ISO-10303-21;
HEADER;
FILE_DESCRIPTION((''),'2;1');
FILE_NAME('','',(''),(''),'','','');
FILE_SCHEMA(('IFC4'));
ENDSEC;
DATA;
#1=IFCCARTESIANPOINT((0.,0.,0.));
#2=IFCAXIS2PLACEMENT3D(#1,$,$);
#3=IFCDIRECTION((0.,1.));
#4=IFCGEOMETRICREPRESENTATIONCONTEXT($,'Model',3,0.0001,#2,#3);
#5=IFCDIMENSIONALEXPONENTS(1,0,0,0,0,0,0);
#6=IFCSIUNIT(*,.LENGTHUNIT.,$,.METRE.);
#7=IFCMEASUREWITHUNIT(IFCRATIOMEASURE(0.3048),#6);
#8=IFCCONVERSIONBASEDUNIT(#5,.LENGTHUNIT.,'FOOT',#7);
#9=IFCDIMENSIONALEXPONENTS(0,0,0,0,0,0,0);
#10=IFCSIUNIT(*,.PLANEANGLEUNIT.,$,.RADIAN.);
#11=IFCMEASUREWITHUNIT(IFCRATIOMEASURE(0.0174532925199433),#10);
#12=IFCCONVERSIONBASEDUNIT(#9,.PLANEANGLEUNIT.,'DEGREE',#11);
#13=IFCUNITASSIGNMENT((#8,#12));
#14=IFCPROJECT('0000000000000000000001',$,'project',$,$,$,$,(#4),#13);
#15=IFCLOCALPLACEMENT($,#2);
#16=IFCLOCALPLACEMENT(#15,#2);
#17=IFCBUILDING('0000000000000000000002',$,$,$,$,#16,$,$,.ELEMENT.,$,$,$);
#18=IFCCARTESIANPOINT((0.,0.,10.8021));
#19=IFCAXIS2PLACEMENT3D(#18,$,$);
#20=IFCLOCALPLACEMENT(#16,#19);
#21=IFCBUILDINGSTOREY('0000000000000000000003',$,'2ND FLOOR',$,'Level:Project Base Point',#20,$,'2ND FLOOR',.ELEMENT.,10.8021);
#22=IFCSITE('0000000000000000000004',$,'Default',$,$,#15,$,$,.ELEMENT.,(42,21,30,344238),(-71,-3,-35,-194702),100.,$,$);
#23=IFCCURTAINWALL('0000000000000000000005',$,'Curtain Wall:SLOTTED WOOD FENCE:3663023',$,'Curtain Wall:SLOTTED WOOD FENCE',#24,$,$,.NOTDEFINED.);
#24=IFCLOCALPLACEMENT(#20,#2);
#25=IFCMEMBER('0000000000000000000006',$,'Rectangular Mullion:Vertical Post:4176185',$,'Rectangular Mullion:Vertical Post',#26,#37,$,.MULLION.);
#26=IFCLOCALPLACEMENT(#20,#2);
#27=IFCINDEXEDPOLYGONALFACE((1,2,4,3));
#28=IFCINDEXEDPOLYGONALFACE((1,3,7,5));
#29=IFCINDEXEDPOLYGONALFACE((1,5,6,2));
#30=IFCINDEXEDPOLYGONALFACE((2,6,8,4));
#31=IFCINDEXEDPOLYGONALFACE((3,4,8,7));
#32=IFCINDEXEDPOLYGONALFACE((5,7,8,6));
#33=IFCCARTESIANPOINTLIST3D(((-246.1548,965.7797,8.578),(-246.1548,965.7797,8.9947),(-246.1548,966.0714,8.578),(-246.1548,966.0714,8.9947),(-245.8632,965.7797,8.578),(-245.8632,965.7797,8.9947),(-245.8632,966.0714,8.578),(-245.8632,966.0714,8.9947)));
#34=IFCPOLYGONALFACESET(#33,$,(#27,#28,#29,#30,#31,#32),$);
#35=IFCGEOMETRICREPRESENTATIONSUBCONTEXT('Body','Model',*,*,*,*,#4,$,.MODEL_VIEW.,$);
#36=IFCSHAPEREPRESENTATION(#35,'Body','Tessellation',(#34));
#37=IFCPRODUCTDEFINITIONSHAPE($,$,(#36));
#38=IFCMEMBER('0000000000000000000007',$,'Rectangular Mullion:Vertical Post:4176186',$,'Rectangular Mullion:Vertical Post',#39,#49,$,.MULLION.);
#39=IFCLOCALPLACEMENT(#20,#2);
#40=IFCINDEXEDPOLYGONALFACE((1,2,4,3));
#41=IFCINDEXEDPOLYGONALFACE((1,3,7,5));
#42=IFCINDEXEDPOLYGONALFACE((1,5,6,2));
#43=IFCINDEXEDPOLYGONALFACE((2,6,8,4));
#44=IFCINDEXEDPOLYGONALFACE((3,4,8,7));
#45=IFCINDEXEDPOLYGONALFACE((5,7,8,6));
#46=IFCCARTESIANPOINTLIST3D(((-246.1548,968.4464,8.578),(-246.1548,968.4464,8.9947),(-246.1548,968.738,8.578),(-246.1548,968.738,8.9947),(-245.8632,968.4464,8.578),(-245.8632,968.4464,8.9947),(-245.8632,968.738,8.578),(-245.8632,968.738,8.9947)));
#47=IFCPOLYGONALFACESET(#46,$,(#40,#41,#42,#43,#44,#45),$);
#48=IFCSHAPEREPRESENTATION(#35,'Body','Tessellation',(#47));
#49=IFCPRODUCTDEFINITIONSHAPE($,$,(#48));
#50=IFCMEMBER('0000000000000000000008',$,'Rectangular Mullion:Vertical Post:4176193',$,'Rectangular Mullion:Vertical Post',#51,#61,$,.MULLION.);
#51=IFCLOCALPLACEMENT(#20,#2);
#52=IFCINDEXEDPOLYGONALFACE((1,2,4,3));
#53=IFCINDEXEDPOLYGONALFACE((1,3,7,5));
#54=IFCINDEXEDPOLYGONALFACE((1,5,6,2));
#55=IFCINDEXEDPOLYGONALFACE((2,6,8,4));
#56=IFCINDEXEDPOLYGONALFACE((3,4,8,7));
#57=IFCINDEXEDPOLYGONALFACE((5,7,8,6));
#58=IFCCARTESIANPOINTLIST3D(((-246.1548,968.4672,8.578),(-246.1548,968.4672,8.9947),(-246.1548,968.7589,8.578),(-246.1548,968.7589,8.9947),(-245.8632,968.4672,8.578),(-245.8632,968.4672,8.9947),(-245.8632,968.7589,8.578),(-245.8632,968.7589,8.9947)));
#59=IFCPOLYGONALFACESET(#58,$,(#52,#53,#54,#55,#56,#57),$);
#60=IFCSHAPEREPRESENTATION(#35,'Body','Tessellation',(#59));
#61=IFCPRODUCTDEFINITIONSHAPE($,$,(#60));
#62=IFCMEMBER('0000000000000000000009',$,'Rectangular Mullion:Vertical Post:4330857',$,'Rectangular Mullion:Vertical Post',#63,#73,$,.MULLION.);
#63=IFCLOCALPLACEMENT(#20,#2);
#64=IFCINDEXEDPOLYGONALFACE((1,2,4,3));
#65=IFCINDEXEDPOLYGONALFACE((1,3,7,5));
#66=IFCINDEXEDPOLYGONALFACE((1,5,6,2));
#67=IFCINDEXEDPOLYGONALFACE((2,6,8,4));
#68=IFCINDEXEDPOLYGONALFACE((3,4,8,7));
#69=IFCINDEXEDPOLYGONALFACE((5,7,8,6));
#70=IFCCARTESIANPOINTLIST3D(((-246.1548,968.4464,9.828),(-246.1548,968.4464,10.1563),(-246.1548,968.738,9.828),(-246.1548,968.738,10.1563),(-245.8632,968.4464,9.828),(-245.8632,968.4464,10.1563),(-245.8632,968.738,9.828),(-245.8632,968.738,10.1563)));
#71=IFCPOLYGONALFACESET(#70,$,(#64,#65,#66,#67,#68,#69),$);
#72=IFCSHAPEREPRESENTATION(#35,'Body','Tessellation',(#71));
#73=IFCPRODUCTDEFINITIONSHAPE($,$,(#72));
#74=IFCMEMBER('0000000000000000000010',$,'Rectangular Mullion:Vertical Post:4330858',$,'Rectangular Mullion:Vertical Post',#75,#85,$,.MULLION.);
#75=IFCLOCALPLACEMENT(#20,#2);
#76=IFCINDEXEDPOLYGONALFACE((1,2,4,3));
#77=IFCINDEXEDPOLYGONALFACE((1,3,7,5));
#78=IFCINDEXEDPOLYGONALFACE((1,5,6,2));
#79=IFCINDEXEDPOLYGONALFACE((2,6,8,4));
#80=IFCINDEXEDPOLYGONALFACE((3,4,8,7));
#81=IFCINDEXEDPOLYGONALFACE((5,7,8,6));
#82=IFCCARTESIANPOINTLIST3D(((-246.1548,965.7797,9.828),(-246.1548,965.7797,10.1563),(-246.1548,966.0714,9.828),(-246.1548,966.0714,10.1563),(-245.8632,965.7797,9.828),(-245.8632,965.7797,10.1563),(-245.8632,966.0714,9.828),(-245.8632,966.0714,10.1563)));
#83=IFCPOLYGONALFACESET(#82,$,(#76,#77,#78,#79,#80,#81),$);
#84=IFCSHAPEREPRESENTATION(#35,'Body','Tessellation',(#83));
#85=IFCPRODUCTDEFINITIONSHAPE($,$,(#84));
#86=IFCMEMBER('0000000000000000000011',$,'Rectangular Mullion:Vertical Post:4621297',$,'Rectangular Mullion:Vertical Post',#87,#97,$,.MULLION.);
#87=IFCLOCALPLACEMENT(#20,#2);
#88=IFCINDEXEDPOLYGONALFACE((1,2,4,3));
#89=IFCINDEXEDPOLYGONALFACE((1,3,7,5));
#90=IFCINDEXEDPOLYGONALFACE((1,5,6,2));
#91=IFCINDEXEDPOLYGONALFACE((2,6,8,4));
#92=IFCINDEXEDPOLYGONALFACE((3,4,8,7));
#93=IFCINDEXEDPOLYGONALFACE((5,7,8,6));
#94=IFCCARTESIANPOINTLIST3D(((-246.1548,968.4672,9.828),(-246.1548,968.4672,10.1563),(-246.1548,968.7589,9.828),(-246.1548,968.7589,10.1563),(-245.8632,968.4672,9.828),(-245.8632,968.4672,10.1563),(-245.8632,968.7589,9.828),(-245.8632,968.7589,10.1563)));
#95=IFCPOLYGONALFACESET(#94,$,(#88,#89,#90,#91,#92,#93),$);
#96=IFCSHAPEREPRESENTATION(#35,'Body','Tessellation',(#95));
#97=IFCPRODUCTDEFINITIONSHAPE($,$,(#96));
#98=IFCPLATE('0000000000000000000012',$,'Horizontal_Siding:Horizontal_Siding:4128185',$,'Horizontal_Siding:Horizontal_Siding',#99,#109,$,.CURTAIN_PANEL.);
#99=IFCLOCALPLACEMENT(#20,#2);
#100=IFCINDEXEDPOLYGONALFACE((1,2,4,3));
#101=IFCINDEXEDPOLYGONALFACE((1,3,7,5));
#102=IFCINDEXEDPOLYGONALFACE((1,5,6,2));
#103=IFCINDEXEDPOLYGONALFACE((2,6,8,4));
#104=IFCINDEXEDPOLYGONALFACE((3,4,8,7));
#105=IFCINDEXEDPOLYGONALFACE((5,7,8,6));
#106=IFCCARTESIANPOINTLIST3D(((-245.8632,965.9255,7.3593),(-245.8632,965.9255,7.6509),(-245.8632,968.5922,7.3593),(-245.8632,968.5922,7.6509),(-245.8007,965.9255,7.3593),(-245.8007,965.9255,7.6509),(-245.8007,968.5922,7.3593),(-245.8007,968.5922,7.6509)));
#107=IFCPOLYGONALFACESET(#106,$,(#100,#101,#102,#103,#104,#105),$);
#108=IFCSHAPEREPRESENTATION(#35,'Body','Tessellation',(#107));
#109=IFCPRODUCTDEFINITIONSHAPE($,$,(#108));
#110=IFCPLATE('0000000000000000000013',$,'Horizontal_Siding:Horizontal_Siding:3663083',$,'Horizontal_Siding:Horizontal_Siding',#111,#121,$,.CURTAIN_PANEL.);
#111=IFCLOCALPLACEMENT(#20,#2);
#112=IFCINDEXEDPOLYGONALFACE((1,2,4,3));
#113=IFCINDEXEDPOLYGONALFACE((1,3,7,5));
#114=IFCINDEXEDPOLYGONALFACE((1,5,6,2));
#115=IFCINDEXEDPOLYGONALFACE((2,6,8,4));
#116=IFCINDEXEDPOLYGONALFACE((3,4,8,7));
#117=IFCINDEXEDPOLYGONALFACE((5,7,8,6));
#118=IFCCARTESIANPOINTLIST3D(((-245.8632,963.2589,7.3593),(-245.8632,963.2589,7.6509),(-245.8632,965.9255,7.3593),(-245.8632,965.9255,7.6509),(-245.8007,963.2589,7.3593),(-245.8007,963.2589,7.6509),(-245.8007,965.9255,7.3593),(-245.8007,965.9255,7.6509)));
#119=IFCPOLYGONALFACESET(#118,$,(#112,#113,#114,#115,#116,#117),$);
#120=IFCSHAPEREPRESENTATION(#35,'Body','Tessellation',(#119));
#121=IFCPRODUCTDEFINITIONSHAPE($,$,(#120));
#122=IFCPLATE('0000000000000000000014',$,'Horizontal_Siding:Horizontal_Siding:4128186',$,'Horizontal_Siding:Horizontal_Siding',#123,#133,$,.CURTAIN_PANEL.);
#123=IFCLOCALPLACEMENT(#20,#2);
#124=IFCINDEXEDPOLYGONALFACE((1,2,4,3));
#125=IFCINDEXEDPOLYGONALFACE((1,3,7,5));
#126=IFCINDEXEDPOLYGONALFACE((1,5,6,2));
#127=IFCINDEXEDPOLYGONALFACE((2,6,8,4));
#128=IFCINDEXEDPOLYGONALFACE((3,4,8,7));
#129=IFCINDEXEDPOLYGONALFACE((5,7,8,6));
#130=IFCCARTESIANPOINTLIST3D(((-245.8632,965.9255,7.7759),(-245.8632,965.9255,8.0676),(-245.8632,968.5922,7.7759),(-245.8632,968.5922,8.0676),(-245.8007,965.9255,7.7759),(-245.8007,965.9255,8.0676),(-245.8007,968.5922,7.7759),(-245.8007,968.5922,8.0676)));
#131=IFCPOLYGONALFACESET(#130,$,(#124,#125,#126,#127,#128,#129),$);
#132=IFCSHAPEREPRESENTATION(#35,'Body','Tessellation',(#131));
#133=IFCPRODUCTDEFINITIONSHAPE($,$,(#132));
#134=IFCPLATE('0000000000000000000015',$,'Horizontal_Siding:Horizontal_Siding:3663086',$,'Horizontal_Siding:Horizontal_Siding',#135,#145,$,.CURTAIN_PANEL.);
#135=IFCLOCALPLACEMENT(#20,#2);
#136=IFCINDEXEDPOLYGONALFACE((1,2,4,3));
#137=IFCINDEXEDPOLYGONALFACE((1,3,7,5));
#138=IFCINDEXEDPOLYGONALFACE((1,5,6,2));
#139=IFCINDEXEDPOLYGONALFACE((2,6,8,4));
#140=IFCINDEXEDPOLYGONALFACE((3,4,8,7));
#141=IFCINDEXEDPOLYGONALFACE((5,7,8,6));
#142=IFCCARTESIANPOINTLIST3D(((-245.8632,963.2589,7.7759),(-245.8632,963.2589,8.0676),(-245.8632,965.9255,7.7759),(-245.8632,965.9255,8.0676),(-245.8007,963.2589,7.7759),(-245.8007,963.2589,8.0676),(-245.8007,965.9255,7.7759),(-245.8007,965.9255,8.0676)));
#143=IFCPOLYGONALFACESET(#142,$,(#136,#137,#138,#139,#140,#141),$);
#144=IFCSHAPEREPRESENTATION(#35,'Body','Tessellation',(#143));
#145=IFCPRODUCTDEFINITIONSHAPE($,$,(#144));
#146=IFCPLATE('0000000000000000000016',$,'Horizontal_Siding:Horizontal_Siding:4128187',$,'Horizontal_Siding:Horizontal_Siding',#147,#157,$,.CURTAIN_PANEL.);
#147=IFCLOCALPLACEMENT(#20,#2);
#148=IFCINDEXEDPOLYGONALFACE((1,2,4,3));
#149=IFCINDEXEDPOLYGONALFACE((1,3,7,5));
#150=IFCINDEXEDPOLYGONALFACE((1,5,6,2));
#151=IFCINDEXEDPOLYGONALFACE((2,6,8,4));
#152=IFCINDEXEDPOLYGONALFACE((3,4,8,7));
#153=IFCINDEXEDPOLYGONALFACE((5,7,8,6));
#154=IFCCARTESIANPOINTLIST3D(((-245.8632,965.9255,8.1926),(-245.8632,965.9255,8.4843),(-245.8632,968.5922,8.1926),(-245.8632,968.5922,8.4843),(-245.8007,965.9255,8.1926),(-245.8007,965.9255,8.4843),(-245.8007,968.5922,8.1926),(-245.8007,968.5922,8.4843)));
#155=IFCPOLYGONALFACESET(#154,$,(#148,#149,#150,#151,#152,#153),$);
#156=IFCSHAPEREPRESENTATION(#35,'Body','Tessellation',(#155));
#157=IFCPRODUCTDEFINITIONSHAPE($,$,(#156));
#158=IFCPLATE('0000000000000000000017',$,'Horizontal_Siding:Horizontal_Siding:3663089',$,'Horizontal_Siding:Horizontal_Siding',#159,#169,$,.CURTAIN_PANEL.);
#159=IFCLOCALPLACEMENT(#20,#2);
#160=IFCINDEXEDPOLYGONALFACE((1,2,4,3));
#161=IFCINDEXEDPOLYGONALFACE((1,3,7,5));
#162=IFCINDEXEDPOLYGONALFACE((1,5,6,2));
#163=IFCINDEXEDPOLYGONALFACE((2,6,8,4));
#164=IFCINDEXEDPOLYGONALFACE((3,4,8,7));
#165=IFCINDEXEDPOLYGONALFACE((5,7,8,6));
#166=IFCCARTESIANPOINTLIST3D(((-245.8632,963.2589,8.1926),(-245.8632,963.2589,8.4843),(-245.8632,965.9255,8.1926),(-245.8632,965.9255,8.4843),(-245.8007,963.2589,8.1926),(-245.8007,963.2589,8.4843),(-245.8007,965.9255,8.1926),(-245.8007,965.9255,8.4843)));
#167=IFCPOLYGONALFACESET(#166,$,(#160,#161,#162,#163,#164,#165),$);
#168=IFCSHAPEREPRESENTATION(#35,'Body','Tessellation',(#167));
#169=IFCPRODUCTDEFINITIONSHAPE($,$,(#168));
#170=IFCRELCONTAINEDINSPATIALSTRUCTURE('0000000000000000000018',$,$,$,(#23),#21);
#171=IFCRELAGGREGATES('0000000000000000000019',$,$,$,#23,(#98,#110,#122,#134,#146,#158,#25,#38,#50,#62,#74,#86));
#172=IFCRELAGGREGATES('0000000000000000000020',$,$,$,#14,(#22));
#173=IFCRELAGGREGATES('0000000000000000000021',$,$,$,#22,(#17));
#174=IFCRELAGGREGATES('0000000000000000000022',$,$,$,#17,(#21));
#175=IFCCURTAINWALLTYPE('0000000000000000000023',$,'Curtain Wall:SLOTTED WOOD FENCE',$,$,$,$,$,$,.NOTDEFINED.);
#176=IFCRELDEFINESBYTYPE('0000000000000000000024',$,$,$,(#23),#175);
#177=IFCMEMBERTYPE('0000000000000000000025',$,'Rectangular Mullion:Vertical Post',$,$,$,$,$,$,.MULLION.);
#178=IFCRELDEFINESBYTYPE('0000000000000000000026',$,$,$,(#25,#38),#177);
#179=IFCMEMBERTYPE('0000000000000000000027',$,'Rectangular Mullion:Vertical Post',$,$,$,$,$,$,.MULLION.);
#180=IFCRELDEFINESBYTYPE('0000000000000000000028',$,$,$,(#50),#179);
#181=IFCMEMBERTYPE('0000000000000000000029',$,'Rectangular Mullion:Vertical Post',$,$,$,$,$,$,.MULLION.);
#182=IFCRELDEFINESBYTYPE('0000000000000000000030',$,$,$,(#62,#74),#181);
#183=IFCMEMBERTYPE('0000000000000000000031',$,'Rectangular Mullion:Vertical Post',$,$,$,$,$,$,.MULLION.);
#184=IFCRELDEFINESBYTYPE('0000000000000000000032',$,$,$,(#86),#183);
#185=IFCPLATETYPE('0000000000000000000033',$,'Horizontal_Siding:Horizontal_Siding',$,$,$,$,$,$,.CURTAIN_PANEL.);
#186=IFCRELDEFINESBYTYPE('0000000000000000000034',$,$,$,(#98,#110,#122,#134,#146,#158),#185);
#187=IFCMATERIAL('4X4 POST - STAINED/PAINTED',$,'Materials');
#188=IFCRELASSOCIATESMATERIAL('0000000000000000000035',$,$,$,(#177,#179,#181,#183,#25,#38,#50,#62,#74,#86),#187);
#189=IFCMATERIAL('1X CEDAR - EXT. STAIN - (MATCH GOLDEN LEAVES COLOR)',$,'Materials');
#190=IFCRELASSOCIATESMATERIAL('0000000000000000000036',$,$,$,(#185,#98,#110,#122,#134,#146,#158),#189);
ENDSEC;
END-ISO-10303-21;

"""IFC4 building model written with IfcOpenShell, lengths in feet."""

from ifc_helpers import new_model, entity, si_unit, converted_unit, direction, frame, origin, origin_2d_with_axis, place, context, subcontext, project, spatial, rectangle, extrude, source, transform, mapped, material, material_profile, profile_set, profile_usage, type_object, type_shapes, element, aggregate, save


model = new_model("IFC4")

# Units and contexts
model_context = context("Model", 3, precision=0.0001, world=origin(), true_north=direction((0.0, 1.0)))
body_context = subcontext(model_context, "Body", "Model", "MODEL_VIEW")
ifc_project = project(units=[converted_unit("LENGTHUNIT", "FOOT", entity("IfcRatioMeasure", 0.3048), si_unit("LENGTHUNIT", "METRE"), dimensions=[1, 0, 0, 0, 0, 0, 0]), converted_unit("PLANEANGLEUNIT", "DEGREE", entity("IfcRatioMeasure", 0.0174532925199433), si_unit("PLANEANGLEUNIT", "RADIAN"), dimensions=[0, 0, 0, 0, 0, 0, 0])], contexts=[model_context])

# Site, building, storey
site_placement = place(None, origin())
site = spatial("IfcSite", under=ifc_project, at=site_placement, Name="Default", CompositionType="ELEMENT", RefLatitude=(42, 21, 30, 344238), RefLongitude=(-71, -3, -35, -194702), RefElevation=100.0)
building_placement = place(site_placement, origin())
building = spatial("IfcBuilding", under=site, at=building_placement, CompositionType="ELEMENT")
storey_placement = place(building_placement, frame((0.0, 0.0, 10.8021)))
storey = spatial("IfcBuildingStorey", under=building, at=storey_placement, Name="2ND FLOOR", ObjectType="Level:Project Base Point", LongName="2ND FLOOR", CompositionType="ELEMENT", Elevation=10.8021)

# Curtain wall, members, plates
curtain_wall_type = type_object("IfcCurtainWallType", Name="Curtain Wall:SLOTTED WOOD FENCE", PredefinedType="NOTDEFINED")
curtain_wall_placement = place(storey_placement, frame((0.0, 0.0, -10.8021)))
curtain_wall = element("IfcCurtainWall", 1, at=curtain_wall_placement, inside=storey, type_object=curtain_wall_type, Name="Curtain Wall:SLOTTED WOOD FENCE:3663023", ObjectType="Curtain Wall:SLOTTED WOOD FENCE", PredefinedType="NOTDEFINED")
ifc_material_1 = material(Name="4X4 POST - STAINED/PAINTED", Category="Materials")
ifc_material_profile = material_profile(ifc_material_1, rectangle(XDim=0.2917, YDim=0.2917, at=origin_2d_with_axis()), Name="Vertical Post")
ifc_profile_set = profile_set([ifc_material_profile], Name="Vertical Post")
ifc_profile_usage_1 = profile_usage(ifc_profile_set)
member_type_1 = type_object("IfcMemberType", Name="Rectangular Mullion:Vertical Post", PredefinedType="MULLION", material=ifc_profile_set)
shared_shape_1 = source(origin(), body_context, "Body", "SweptSolid", [
    extrude(rectangle(XDim=0.2917, YDim=0.2917, at=origin_2d_with_axis()), frame((0.0, 0.2083, -0.4167), z_axis=(0.0, 0.0, 1.0), x_axis=(0.0, -1.0, 0.0)), (0.0, 0.0, 1.0), 0.4167),
])
type_shapes(member_type_1, [shared_shape_1])
member_1_placement = place(storey_placement, frame((-245.8007, 965.9255, 8.578), z_axis=(0.0, 0.0, -1.0), x_axis=(0.0, -1.0, 0.0)))
member_1 = element("IfcMember", 2, at=member_1_placement, type_object=member_type_1, material=ifc_profile_usage_1, Name="Rectangular Mullion:Vertical Post:4176185", ObjectType="Rectangular Mullion:Vertical Post", PredefinedType="MULLION", context=body_context, shape_type="MappedRepresentation", body=[
    mapped(shared_shape_1, transform((0.0, 0.0, 0.0), scale=1.0)),
])
ifc_profile_usage_2 = profile_usage(ifc_profile_set)
member_2_placement = place(storey_placement, frame((-245.8007, 968.5922, 8.578), z_axis=(0.0, 0.0, -1.0), x_axis=(0.0, -1.0, 0.0)))
member_2 = element("IfcMember", 3, at=member_2_placement, type_object=member_type_1, material=ifc_profile_usage_2, Name="Rectangular Mullion:Vertical Post:4176186", ObjectType="Rectangular Mullion:Vertical Post", PredefinedType="MULLION", context=body_context, shape_type="MappedRepresentation", body=[
    mapped(shared_shape_1, transform((0.0, 0.0, 0.0), scale=1.0)),
])
ifc_profile_usage_3 = profile_usage(ifc_profile_set)
member_type_2 = type_object("IfcMemberType", Name="Rectangular Mullion:Vertical Post", PredefinedType="MULLION", material=ifc_profile_set)
shared_shape_2 = source(origin(), body_context, "Body", "SweptSolid", [
    extrude(rectangle(XDim=0.2917, YDim=0.2917, at=origin_2d_with_axis()), frame((-0.1458, 0.2083, -0.4167), z_axis=(0.0, 0.0, 1.0), x_axis=(0.0, -1.0, 0.0)), (0.0, 0.0, 1.0), 0.4167),
])
type_shapes(member_type_2, [shared_shape_2])
member_3_placement = place(storey_placement, frame((-245.8007, 968.7589, 8.9947), z_axis=(0.0, 0.0, 1.0), x_axis=(0.0, 1.0, 0.0)))
member_3 = element("IfcMember", 4, at=member_3_placement, type_object=member_type_2, material=ifc_profile_usage_3, Name="Rectangular Mullion:Vertical Post:4176193", ObjectType="Rectangular Mullion:Vertical Post", PredefinedType="MULLION", context=body_context, shape_type="MappedRepresentation", body=[
    mapped(shared_shape_2, transform((0.0, 0.0, 0.0), scale=1.0)),
])
ifc_profile_usage_4 = profile_usage(ifc_profile_set)
member_type_3 = type_object("IfcMemberType", Name="Rectangular Mullion:Vertical Post", PredefinedType="MULLION", material=ifc_profile_set)
shared_shape_3 = source(origin(), body_context, "Body", "SweptSolid", [
    extrude(rectangle(XDim=0.2917, YDim=0.2917, at=origin_2d_with_axis()), frame((0.0, 0.2083, -0.3282), z_axis=(0.0, 0.0, 1.0), x_axis=(0.0, -1.0, 0.0)), (0.0, 0.0, 1.0), 0.3282),
])
type_shapes(member_type_3, [shared_shape_3])
member_4_placement = place(storey_placement, frame((-245.8007, 968.5922, 9.828), z_axis=(0.0, 0.0, -1.0), x_axis=(0.0, -1.0, 0.0)))
member_4 = element("IfcMember", 5, at=member_4_placement, type_object=member_type_3, material=ifc_profile_usage_4, Name="Rectangular Mullion:Vertical Post:4330857", ObjectType="Rectangular Mullion:Vertical Post", PredefinedType="MULLION", context=body_context, shape_type="MappedRepresentation", body=[
    mapped(shared_shape_3, transform((0.0, 0.0, 0.0), scale=1.0)),
])
ifc_profile_usage_5 = profile_usage(ifc_profile_set)
member_5_placement = place(storey_placement, frame((-245.8007, 965.9255, 9.828), z_axis=(0.0, 0.0, -1.0), x_axis=(0.0, -1.0, 0.0)))
member_5 = element("IfcMember", 6, at=member_5_placement, type_object=member_type_3, material=ifc_profile_usage_5, Name="Rectangular Mullion:Vertical Post:4330858", ObjectType="Rectangular Mullion:Vertical Post", PredefinedType="MULLION", context=body_context, shape_type="MappedRepresentation", body=[
    mapped(shared_shape_3, transform((0.0, 0.0, 0.0), scale=1.0)),
])
ifc_profile_usage_6 = profile_usage(ifc_profile_set)
member_type_4 = type_object("IfcMemberType", Name="Rectangular Mullion:Vertical Post", PredefinedType="MULLION", material=ifc_profile_set)
shared_shape_4 = source(origin(), body_context, "Body", "SweptSolid", [
    extrude(rectangle(XDim=0.2917, YDim=0.2917, at=origin_2d_with_axis()), frame((-0.1458, 0.2083, -0.3282), z_axis=(0.0, 0.0, 1.0), x_axis=(0.0, -1.0, 0.0)), (0.0, 0.0, 1.0), 0.3282),
])
type_shapes(member_type_4, [shared_shape_4])
member_6_placement = place(storey_placement, frame((-245.8007, 968.7589, 10.1562), z_axis=(0.0, 0.0, 1.0), x_axis=(0.0, 1.0, 0.0)))
member_6 = element("IfcMember", 7, at=member_6_placement, type_object=member_type_4, material=ifc_profile_usage_6, Name="Rectangular Mullion:Vertical Post:4621297", ObjectType="Rectangular Mullion:Vertical Post", PredefinedType="MULLION", context=body_context, shape_type="MappedRepresentation", body=[
    mapped(shared_shape_4, transform((0.0, 0.0, 0.0), scale=1.0)),
])
ifc_material_2 = material(Name="1X CEDAR - EXT. STAIN - (MATCH GOLDEN LEAVES COLOR)", Category="Materials")
plate_type_1 = type_object("IfcPlateType", Name="Horizontal_Siding:Horizontal_Siding", PredefinedType="CURTAIN_PANEL", material=ifc_material_2)
shared_shape_5 = source(origin(), body_context, "Body", "SweptSolid", [
    extrude(rectangle(XDim=0.0625, YDim=2.6667, at=origin_2d_with_axis()), frame((1.3333, 0.0312, 0.0), z_axis=(0.0, 0.0, 1.0), x_axis=(0.0, 1.0, 0.0)), (0.0, 0.0, 1.0), 0.2917),
])
type_shapes(plate_type_1, [shared_shape_5])
plate_1_placement = place(curtain_wall_placement, frame((-245.8632, 968.5922, 18.1613), z_axis=(0.0, 0.0, 1.0), x_axis=(0.0, -1.0, 0.0)))
plate_1 = element("IfcPlate", 8, at=plate_1_placement, type_object=plate_type_1, material=ifc_material_2, Name="Horizontal_Siding:Horizontal_Siding:4128185", ObjectType="Horizontal_Siding:Horizontal_Siding", PredefinedType="CURTAIN_PANEL", context=body_context, shape_type="MappedRepresentation", body=[
    mapped(shared_shape_5, transform((0.0, 0.0, 0.0), scale=1.0)),
])
plate_2_placement = place(curtain_wall_placement, frame((-245.8632, 965.9255, 18.1613), z_axis=(0.0, 0.0, 1.0), x_axis=(0.0, -1.0, 0.0)))
plate_2 = element("IfcPlate", 9, at=plate_2_placement, type_object=plate_type_1, material=ifc_material_2, Name="Horizontal_Siding:Horizontal_Siding:3663083", ObjectType="Horizontal_Siding:Horizontal_Siding", PredefinedType="CURTAIN_PANEL", context=body_context, shape_type="MappedRepresentation", body=[
    mapped(shared_shape_5, transform((0.0, 0.0, 0.0), scale=1.0)),
])
plate_3_placement = place(curtain_wall_placement, frame((-245.8632, 968.5922, 18.578), z_axis=(0.0, 0.0, 1.0), x_axis=(0.0, -1.0, 0.0)))
plate_3 = element("IfcPlate", 10, at=plate_3_placement, type_object=plate_type_1, material=ifc_material_2, Name="Horizontal_Siding:Horizontal_Siding:4128186", ObjectType="Horizontal_Siding:Horizontal_Siding", PredefinedType="CURTAIN_PANEL", context=body_context, shape_type="MappedRepresentation", body=[
    mapped(shared_shape_5, transform((0.0, 0.0, 0.0), scale=1.0)),
])
plate_4_placement = place(curtain_wall_placement, frame((-245.8632, 965.9255, 18.578), z_axis=(0.0, 0.0, 1.0), x_axis=(0.0, -1.0, 0.0)))
plate_4 = element("IfcPlate", 11, at=plate_4_placement, type_object=plate_type_1, material=ifc_material_2, Name="Horizontal_Siding:Horizontal_Siding:3663086", ObjectType="Horizontal_Siding:Horizontal_Siding", PredefinedType="CURTAIN_PANEL", context=body_context, shape_type="MappedRepresentation", body=[
    mapped(shared_shape_5, transform((0.0, 0.0, 0.0), scale=1.0)),
])
plate_5_placement = place(curtain_wall_placement, frame((-245.8632, 968.5922, 18.9947), z_axis=(0.0, 0.0, 1.0), x_axis=(0.0, -1.0, 0.0)))
plate_5 = element("IfcPlate", 12, at=plate_5_placement, type_object=plate_type_1, material=ifc_material_2, Name="Horizontal_Siding:Horizontal_Siding:4128187", ObjectType="Horizontal_Siding:Horizontal_Siding", PredefinedType="CURTAIN_PANEL", context=body_context, shape_type="MappedRepresentation", body=[
    mapped(shared_shape_5, transform((0.0, 0.0, 0.0), scale=1.0)),
])
plate_6_placement = place(curtain_wall_placement, frame((-245.8632, 965.9255, 18.9947), z_axis=(0.0, 0.0, 1.0), x_axis=(0.0, -1.0, 0.0)))
plate_6 = element("IfcPlate", 13, at=plate_6_placement, type_object=plate_type_1, material=ifc_material_2, Name="Horizontal_Siding:Horizontal_Siding:3663089", ObjectType="Horizontal_Siding:Horizontal_Siding", PredefinedType="CURTAIN_PANEL", context=body_context, shape_type="MappedRepresentation", body=[
    mapped(shared_shape_5, transform((0.0, 0.0, 0.0), scale=1.0)),
])
aggregate(curtain_wall, [plate_1, plate_2, plate_3, plate_4, plate_5, plate_6, member_1, member_2, member_3, member_4, member_5, member_6])

save(model, "model.ifc")
